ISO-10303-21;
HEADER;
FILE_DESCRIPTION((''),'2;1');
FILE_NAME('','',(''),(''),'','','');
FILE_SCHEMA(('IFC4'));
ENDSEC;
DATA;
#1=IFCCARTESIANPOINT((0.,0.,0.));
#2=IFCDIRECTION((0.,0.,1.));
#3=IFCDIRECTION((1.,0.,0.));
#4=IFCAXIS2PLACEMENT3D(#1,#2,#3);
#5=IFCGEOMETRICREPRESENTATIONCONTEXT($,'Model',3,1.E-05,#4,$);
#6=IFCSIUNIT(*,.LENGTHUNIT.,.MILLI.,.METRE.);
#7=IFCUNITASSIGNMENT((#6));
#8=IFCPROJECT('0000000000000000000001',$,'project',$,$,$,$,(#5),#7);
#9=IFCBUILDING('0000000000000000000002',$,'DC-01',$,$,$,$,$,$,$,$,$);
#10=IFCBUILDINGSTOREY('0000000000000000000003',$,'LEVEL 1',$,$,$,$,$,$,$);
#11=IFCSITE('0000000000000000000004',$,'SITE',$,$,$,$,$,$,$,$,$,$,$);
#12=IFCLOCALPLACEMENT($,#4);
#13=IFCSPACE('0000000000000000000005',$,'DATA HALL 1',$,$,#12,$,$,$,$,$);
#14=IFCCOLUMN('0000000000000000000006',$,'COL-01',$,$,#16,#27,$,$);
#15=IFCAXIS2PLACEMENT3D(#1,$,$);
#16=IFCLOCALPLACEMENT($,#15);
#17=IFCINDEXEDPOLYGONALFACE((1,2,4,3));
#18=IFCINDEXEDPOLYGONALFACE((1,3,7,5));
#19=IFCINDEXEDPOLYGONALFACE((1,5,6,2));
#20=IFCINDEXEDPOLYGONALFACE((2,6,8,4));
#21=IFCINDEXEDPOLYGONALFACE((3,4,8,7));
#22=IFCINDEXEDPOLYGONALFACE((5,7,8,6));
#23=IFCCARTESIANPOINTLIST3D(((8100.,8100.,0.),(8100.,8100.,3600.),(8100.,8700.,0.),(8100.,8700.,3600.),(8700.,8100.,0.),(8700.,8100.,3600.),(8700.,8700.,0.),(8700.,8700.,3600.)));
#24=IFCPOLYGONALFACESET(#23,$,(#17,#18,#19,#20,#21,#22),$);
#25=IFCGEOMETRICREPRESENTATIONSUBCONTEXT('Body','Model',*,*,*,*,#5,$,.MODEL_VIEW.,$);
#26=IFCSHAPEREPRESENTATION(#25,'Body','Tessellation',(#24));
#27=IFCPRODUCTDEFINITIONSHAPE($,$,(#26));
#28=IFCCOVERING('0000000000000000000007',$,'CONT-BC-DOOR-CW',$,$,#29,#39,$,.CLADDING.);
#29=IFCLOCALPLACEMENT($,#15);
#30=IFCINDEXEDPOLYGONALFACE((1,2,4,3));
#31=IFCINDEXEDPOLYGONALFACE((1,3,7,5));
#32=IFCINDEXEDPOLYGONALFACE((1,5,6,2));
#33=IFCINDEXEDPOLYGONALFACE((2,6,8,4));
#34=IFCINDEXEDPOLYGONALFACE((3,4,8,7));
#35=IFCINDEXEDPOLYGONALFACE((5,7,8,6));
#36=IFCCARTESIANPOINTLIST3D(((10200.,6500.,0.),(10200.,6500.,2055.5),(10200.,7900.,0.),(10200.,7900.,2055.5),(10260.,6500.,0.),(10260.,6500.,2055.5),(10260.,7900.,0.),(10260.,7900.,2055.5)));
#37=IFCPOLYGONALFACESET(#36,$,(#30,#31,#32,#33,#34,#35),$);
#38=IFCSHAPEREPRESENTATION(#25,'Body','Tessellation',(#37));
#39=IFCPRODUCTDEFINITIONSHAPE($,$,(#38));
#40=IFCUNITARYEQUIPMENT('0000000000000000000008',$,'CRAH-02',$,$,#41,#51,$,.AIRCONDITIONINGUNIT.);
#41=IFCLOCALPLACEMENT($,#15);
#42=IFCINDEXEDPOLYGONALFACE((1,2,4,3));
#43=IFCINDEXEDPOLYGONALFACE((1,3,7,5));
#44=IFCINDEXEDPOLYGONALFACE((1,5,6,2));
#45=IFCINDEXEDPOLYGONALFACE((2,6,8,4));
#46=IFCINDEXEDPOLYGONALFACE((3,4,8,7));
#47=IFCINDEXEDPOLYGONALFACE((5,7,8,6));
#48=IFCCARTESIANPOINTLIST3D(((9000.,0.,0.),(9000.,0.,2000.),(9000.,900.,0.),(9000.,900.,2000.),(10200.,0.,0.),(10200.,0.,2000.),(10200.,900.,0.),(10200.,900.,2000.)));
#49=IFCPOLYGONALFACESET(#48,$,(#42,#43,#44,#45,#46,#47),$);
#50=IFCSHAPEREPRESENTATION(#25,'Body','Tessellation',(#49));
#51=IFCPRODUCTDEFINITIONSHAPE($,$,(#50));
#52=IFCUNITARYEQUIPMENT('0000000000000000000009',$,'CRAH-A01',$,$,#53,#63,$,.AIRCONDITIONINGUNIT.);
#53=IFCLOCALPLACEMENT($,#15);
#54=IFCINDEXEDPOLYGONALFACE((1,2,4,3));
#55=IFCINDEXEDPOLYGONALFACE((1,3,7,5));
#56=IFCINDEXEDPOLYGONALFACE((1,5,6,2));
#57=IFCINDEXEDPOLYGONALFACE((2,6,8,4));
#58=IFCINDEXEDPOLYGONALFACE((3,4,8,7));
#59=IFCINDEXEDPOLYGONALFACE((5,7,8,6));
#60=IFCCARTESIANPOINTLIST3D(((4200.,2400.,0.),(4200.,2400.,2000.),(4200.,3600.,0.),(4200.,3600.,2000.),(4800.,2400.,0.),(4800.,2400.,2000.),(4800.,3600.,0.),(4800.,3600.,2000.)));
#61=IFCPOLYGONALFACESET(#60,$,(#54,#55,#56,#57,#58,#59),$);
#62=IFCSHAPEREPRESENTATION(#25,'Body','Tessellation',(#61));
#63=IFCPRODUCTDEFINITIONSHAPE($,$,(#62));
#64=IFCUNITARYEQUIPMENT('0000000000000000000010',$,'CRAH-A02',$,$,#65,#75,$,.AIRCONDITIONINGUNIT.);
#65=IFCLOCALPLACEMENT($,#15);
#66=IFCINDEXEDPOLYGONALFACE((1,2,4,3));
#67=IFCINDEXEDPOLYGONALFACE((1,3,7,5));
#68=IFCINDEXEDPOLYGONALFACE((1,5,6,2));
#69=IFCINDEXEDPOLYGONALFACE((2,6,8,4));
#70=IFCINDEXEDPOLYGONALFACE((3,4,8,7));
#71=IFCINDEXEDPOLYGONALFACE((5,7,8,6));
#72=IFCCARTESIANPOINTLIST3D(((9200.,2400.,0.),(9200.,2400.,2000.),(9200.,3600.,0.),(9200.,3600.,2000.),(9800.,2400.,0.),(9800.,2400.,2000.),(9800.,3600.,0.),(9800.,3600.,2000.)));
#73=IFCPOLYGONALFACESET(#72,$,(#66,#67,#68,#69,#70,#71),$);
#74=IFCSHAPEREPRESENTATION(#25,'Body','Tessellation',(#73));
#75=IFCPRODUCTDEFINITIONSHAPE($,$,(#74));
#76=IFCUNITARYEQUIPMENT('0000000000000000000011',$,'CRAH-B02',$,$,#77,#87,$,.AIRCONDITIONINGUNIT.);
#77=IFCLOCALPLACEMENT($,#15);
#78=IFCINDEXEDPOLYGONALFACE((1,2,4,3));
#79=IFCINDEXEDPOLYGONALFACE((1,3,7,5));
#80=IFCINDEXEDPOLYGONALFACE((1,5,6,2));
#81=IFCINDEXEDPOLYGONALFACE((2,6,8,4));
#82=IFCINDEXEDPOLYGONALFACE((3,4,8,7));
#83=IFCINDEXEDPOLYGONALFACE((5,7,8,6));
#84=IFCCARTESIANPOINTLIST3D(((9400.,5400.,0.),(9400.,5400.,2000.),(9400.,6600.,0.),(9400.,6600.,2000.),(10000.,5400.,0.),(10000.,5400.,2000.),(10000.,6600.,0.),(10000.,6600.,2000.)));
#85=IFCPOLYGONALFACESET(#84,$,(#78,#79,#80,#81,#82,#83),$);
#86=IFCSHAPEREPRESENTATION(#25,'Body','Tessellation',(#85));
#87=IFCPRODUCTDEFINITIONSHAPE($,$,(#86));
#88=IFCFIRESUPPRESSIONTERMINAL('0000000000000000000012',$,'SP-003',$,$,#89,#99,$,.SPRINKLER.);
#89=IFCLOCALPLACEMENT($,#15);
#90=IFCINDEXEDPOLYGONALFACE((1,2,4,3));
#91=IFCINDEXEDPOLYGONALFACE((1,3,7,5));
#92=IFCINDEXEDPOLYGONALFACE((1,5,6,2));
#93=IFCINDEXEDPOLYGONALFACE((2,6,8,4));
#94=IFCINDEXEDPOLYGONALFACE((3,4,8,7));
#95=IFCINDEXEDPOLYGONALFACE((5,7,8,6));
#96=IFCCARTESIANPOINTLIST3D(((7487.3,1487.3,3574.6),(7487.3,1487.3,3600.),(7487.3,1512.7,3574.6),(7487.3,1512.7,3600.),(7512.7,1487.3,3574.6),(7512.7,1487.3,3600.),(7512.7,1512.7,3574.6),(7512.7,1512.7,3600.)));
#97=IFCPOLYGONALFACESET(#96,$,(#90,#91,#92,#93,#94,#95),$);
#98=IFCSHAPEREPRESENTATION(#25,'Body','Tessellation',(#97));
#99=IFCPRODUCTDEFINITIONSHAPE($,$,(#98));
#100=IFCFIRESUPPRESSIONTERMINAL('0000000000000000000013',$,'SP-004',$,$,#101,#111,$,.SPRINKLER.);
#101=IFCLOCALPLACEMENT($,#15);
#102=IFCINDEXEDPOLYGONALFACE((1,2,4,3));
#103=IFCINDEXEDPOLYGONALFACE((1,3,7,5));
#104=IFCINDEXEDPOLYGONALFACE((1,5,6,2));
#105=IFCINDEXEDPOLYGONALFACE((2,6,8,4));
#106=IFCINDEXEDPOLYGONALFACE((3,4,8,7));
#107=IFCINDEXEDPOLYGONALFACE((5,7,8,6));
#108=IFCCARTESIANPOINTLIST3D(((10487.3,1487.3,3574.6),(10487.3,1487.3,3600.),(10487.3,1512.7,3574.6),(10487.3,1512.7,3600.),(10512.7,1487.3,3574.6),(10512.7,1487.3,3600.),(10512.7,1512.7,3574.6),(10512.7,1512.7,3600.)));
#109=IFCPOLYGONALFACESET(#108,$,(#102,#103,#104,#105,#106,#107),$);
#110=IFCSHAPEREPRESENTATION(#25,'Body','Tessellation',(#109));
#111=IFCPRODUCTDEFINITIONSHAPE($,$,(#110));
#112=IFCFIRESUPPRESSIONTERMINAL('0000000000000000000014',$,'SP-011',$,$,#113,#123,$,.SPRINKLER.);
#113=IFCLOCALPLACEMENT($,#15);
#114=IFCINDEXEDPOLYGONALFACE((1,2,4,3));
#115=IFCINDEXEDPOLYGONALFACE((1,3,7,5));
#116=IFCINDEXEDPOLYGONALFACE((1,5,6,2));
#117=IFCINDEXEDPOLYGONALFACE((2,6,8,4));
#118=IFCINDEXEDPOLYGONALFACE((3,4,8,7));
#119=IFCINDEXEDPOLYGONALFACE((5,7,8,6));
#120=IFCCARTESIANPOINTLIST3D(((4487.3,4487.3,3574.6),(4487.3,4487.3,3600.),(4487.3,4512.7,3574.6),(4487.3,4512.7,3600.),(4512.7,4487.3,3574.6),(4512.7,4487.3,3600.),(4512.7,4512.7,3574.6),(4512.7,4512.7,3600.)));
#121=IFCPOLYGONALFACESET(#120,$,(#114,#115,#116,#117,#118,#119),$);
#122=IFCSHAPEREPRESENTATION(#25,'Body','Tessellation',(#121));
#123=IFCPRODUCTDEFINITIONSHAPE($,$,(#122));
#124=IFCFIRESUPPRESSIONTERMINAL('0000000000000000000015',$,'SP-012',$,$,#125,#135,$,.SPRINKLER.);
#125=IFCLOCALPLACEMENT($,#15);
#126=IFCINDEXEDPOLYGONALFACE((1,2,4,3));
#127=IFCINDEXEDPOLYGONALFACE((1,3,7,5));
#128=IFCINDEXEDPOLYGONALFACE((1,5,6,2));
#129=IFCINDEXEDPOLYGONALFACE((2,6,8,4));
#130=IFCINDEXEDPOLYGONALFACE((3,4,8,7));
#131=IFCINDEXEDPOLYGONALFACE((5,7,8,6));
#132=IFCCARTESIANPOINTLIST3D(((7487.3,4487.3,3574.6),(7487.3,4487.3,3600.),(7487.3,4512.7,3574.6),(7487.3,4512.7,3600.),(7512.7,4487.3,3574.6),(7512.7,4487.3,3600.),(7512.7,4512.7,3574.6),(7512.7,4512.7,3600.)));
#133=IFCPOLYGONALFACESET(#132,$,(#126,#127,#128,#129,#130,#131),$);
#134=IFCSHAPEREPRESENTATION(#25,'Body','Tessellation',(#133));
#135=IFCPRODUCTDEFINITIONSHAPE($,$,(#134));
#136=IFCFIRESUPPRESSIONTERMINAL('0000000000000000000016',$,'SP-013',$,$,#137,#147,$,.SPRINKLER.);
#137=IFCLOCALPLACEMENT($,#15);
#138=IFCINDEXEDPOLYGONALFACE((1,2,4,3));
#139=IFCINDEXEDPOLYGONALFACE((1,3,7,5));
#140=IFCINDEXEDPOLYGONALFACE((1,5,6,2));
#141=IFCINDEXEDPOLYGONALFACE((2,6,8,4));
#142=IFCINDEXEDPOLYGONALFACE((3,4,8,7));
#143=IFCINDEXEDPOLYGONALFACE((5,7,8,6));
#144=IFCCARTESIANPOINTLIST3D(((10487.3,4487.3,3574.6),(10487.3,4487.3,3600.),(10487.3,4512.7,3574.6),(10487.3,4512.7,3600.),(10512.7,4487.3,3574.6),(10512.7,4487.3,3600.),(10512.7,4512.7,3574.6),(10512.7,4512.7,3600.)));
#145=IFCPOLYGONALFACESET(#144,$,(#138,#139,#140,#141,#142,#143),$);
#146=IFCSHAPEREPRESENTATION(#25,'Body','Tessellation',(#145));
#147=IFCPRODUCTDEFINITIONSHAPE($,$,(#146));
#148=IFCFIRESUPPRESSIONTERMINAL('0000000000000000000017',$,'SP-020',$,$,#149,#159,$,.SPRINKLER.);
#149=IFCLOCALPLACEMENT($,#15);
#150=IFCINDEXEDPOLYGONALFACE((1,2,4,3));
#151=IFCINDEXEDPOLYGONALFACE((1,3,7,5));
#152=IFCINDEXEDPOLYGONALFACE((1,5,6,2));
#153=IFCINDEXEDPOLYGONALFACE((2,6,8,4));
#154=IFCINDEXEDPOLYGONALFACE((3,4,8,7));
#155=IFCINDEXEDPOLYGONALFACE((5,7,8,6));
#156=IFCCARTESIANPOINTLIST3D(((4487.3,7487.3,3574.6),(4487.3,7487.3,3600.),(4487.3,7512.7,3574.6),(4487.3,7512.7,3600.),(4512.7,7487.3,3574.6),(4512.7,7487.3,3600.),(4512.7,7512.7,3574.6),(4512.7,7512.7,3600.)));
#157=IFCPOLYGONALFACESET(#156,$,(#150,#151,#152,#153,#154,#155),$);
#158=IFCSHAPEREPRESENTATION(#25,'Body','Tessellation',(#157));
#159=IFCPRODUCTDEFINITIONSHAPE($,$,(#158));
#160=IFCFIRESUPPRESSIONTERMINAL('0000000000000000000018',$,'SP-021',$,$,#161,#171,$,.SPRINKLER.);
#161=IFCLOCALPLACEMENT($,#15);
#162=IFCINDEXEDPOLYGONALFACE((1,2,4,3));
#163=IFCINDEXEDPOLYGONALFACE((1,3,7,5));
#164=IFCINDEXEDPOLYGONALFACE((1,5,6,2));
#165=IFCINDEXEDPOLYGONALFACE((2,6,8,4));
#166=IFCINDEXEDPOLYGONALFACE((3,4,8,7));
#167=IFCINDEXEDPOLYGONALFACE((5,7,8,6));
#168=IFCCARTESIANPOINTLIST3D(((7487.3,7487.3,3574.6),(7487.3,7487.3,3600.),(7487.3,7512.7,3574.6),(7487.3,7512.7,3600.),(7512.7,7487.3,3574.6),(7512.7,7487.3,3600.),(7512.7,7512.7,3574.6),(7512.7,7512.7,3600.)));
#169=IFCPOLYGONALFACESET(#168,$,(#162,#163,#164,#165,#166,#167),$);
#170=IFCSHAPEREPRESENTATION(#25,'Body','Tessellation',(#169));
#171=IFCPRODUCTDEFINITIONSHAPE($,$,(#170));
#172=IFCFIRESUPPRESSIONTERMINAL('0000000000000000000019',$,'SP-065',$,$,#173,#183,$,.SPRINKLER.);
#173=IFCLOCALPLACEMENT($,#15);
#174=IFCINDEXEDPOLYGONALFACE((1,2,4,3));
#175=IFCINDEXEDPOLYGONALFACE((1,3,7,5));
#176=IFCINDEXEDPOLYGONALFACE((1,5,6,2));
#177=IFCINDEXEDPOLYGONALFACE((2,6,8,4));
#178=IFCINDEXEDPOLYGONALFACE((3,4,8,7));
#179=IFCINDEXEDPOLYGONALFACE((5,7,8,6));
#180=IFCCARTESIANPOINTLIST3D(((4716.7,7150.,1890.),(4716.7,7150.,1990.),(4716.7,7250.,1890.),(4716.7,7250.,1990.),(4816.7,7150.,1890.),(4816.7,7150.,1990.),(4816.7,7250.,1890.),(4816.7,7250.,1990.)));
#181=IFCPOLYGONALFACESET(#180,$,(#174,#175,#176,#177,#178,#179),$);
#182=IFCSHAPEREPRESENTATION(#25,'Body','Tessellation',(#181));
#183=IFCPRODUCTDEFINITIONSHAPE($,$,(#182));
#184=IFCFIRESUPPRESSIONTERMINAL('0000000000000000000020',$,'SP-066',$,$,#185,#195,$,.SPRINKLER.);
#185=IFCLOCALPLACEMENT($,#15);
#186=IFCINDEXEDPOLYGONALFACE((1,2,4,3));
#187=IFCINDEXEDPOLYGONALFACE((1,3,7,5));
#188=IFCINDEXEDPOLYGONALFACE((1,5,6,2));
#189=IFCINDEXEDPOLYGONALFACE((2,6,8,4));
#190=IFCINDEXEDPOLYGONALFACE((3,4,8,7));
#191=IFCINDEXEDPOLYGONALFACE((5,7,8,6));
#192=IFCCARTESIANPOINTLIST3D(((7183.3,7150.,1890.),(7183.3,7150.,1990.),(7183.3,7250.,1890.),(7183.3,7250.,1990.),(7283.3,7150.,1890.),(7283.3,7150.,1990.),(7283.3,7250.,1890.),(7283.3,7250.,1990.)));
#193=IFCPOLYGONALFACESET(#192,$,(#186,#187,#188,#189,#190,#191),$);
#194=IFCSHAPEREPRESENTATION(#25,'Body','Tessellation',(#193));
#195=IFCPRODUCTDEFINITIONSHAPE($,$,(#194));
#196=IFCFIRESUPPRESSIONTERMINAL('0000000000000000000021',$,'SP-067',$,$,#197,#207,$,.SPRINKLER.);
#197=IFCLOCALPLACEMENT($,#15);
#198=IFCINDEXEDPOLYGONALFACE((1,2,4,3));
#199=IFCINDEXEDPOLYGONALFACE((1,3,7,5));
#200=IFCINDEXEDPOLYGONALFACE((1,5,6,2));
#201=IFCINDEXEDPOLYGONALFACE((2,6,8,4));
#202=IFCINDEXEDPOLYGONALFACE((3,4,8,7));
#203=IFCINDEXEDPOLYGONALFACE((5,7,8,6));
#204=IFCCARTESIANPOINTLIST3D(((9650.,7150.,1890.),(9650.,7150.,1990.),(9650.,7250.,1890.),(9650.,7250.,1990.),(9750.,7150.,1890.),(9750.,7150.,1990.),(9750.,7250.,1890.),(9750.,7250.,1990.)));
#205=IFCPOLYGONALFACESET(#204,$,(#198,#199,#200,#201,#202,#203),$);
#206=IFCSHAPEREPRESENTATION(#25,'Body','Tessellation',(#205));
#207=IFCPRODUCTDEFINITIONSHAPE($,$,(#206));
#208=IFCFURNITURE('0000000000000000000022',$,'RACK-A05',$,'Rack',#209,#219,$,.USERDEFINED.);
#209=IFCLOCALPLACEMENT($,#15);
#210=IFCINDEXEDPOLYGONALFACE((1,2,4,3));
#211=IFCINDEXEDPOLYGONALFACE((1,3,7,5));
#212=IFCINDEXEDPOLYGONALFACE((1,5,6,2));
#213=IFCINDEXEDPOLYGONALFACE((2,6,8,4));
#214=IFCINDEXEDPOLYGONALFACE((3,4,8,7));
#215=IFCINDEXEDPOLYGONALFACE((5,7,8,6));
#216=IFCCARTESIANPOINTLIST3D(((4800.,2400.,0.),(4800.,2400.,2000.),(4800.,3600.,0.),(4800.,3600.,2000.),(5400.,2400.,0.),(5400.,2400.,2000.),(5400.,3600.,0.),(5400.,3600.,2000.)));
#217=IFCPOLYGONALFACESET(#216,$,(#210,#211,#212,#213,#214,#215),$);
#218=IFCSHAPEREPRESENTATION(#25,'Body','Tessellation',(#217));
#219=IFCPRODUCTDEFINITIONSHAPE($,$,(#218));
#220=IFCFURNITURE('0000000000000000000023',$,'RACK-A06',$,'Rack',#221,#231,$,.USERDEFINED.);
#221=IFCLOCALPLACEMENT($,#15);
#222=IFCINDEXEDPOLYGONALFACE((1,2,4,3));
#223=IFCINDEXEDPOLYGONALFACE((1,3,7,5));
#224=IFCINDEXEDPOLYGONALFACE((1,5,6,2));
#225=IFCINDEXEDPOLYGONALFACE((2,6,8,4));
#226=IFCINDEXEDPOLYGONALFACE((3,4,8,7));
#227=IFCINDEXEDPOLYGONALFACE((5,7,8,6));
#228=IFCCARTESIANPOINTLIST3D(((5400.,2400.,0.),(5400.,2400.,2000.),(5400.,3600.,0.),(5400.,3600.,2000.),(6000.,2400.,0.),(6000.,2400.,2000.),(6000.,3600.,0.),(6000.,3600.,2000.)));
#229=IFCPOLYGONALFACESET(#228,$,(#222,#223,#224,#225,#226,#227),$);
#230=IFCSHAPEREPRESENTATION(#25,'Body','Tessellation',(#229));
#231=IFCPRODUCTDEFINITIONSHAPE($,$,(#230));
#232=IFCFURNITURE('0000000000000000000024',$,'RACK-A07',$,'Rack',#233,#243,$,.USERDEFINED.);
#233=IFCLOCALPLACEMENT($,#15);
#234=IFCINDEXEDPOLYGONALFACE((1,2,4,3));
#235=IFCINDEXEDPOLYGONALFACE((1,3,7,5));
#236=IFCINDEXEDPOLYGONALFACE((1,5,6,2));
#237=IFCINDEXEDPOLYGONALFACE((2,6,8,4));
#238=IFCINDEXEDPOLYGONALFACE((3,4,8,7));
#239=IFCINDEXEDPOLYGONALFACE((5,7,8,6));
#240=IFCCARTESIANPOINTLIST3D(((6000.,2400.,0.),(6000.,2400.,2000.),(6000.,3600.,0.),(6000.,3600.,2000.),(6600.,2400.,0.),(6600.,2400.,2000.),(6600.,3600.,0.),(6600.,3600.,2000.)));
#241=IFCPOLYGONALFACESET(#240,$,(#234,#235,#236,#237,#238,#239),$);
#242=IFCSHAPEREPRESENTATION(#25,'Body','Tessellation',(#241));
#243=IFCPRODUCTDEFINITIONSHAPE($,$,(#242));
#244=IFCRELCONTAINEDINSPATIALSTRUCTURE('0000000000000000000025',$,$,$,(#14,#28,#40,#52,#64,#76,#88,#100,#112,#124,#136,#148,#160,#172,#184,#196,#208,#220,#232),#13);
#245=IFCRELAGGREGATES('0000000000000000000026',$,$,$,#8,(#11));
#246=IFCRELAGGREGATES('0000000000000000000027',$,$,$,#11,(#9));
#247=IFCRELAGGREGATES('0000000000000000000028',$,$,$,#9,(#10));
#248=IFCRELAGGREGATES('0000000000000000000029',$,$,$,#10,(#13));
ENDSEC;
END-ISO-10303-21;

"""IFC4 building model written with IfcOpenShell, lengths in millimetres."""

from ifc_helpers import new_model, si_unit, frame, origin, origin_with_axes, place, context, subcontext, project, spatial, polyline, outline, extrude, element, save


model = new_model("IFC4")

# Units and contexts
model_context = context("Model", 3, precision=1e-05, world=origin_with_axes())
body_context = subcontext(model_context, "Body", "Model", "MODEL_VIEW")
ifc_project = project(units=[si_unit("LENGTHUNIT", "METRE", prefix="MILLI")], contexts=[model_context])

# Site, building, storey, space
site = spatial("IfcSite", under=ifc_project, Name="SITE")
building = spatial("IfcBuilding", under=site, Name="DC-01")
storey = spatial("IfcBuildingStorey", under=building, Name="LEVEL 1")
space_placement = place(None, origin_with_axes())
space = spatial("IfcSpace", under=storey, at=space_placement, Name="DATA HALL 1")

# Column
column_placement = place(space_placement, frame((8100.0, 8100.0, 0.0), z_axis=(0.0, 0.0, 1.0), x_axis=(1.0, 0.0, 0.0)))
element("IfcColumn", 1, at=column_placement, inside=space, Name="COL-01", context=body_context, shape_type="SweptSolid", body=[
    extrude(outline(polyline([(0.0, 0.0), (600.0, 0.0), (600.0, 600.0), (0.0, 600.0), (0.0, 0.0)])), origin(), (0.0, 0.0, 1.0), 3600.0),
])

# Covering
covering_placement = place(space_placement, frame((10200.0, 6500.0, 0.0), z_axis=(0.0, 0.0, 1.0), x_axis=(1.0, 0.0, 0.0)))
element("IfcCovering", 2, at=covering_placement, inside=space, Name="CONT-BC-DOOR-CW", PredefinedType="CLADDING", context=body_context, shape_type="SweptSolid", body=[
    extrude(outline(polyline([(0.0, 0.0), (60.0, 0.0), (60.0, 1400.0), (0.0, 1400.0), (0.0, 0.0)])), origin(), (0.0, 0.0, 1.0), 2055.5),
])

# Unitary equipment
unitary_equipment_placement = place(space_placement, frame((9000.0, 0.0, 0.0), z_axis=(0.0, 0.0, 1.0), x_axis=(1.0, 0.0, 0.0)))
element("IfcUnitaryEquipment", 3, at=unitary_equipment_placement, inside=space, Name="CRAH-02", PredefinedType="AIRCONDITIONINGUNIT", context=body_context, shape_type="SweptSolid", body=[
    extrude(outline(polyline([(0.0, 0.0), (1200.0, 0.0), (1200.0, 900.0), (0.0, 900.0), (0.0, 0.0)])), origin(), (0.0, 0.0, 1.0), 2000.0),
])
for number, where, z_axis, x_axis, name in (
    (4, (4800.0, 3600.0, 0.0), (0.0, 0.0, 1.0), (-1.0, 0.0, 0.0), "CRAH-A01"),
    (5, (9800.0, 3600.0, 0.0), (0.0, 0.0, 1.0), (-1.0, 0.0, 0.0), "CRAH-A02"),
    (6, (9400.0, 5400.0, 0.0), (0.0, 0.0, 1.0), (1.0, 0.0, 0.0), "CRAH-B02"),
):
    element("IfcUnitaryEquipment", number, at=place(space_placement, frame(where, z_axis=z_axis, x_axis=x_axis)), inside=space, Name=name, PredefinedType="AIRCONDITIONINGUNIT", context=body_context, shape_type="SweptSolid", body=[
        extrude(outline(polyline([(0.0, 0.0), (600.0, 0.0), (600.0, 1200.0), (0.0, 1200.0), (0.0, 0.0)])), origin(), (0.0, 0.0, 1.0), 2000.0),
    ])

# Fire suppression terminals
for number, where, z_axis, x_axis, name in (
    (7, (7487.3, 1487.3, 3574.6), (0.0, 0.0, 1.0), (1.0, 0.0, 0.0), "SP-003"),
    (8, (10487.3, 1487.3, 3574.6), (0.0, 0.0, 1.0), (1.0, 0.0, 0.0), "SP-004"),
    (9, (4487.3, 4487.3, 3574.6), (0.0, 0.0, 1.0), (1.0, 0.0, 0.0), "SP-011"),
    (10, (7487.3, 4487.3, 3574.6), (0.0, 0.0, 1.0), (1.0, 0.0, 0.0), "SP-012"),
    (11, (10487.3, 4487.3, 3574.6), (0.0, 0.0, 1.0), (1.0, 0.0, 0.0), "SP-013"),
    (12, (4487.3, 7487.3, 3574.6), (0.0, 0.0, 1.0), (1.0, 0.0, 0.0), "SP-020"),
    (13, (7487.3, 7487.3, 3574.6), (0.0, 0.0, 1.0), (1.0, 0.0, 0.0), "SP-021"),
):
    element("IfcFireSuppressionTerminal", number, at=place(space_placement, frame(where, z_axis=z_axis, x_axis=x_axis)), inside=space, Name=name, PredefinedType="SPRINKLER", context=body_context, shape_type="SweptSolid", body=[
        extrude(outline(polyline([(0.0, 0.0), (25.4, 0.0), (25.4, 25.4), (0.0, 25.4), (0.0, 0.0)])), origin(), (0.0, 0.0, 1.0), 25.4),
    ])
for number, where, z_axis, x_axis, name in (
    (14, (4716.7, 7150.0, 1890.0), (0.0, 0.0, 1.0), (1.0, 0.0, 0.0), "SP-065"),
    (15, (7183.3, 7150.0, 1890.0), (0.0, 0.0, 1.0), (1.0, 0.0, 0.0), "SP-066"),
    (16, (9650.0, 7150.0, 1890.0), (0.0, 0.0, 1.0), (1.0, 0.0, 0.0), "SP-067"),
):
    element("IfcFireSuppressionTerminal", number, at=place(space_placement, frame(where, z_axis=z_axis, x_axis=x_axis)), inside=space, Name=name, PredefinedType="SPRINKLER", context=body_context, shape_type="SweptSolid", body=[
        extrude(outline(polyline([(0.0, 0.0), (100.0, 0.0), (100.0, 100.0), (0.0, 100.0), (0.0, 0.0)])), origin(), (0.0, 0.0, 1.0), 100.0),
    ])

# Furniture
for number, where, z_axis, x_axis, name in (
    (17, (5400.0, 3600.0, 0.0), (0.0, 0.0, 1.0), (-1.0, 0.0, 0.0), "RACK-A05"),
    (18, (6000.0, 3600.0, 0.0), (0.0, 0.0, 1.0), (-1.0, 0.0, 0.0), "RACK-A06"),
    (19, (6600.0, 3600.0, 0.0), (0.0, 0.0, 1.0), (-1.0, 0.0, 0.0), "RACK-A07"),
):
    element("IfcFurniture", number, at=place(space_placement, frame(where, z_axis=z_axis, x_axis=x_axis)), inside=space, Name=name, ObjectType="Rack", PredefinedType="USERDEFINED", context=body_context, shape_type="SweptSolid", body=[
        extrude(outline(polyline([(0.0, 0.0), (600.0, 0.0), (600.0, 1200.0), (0.0, 1200.0), (0.0, 0.0)])), origin(), (0.0, 0.0, 1.0), 2000.0),
    ])

save(model, "model.ifc")
